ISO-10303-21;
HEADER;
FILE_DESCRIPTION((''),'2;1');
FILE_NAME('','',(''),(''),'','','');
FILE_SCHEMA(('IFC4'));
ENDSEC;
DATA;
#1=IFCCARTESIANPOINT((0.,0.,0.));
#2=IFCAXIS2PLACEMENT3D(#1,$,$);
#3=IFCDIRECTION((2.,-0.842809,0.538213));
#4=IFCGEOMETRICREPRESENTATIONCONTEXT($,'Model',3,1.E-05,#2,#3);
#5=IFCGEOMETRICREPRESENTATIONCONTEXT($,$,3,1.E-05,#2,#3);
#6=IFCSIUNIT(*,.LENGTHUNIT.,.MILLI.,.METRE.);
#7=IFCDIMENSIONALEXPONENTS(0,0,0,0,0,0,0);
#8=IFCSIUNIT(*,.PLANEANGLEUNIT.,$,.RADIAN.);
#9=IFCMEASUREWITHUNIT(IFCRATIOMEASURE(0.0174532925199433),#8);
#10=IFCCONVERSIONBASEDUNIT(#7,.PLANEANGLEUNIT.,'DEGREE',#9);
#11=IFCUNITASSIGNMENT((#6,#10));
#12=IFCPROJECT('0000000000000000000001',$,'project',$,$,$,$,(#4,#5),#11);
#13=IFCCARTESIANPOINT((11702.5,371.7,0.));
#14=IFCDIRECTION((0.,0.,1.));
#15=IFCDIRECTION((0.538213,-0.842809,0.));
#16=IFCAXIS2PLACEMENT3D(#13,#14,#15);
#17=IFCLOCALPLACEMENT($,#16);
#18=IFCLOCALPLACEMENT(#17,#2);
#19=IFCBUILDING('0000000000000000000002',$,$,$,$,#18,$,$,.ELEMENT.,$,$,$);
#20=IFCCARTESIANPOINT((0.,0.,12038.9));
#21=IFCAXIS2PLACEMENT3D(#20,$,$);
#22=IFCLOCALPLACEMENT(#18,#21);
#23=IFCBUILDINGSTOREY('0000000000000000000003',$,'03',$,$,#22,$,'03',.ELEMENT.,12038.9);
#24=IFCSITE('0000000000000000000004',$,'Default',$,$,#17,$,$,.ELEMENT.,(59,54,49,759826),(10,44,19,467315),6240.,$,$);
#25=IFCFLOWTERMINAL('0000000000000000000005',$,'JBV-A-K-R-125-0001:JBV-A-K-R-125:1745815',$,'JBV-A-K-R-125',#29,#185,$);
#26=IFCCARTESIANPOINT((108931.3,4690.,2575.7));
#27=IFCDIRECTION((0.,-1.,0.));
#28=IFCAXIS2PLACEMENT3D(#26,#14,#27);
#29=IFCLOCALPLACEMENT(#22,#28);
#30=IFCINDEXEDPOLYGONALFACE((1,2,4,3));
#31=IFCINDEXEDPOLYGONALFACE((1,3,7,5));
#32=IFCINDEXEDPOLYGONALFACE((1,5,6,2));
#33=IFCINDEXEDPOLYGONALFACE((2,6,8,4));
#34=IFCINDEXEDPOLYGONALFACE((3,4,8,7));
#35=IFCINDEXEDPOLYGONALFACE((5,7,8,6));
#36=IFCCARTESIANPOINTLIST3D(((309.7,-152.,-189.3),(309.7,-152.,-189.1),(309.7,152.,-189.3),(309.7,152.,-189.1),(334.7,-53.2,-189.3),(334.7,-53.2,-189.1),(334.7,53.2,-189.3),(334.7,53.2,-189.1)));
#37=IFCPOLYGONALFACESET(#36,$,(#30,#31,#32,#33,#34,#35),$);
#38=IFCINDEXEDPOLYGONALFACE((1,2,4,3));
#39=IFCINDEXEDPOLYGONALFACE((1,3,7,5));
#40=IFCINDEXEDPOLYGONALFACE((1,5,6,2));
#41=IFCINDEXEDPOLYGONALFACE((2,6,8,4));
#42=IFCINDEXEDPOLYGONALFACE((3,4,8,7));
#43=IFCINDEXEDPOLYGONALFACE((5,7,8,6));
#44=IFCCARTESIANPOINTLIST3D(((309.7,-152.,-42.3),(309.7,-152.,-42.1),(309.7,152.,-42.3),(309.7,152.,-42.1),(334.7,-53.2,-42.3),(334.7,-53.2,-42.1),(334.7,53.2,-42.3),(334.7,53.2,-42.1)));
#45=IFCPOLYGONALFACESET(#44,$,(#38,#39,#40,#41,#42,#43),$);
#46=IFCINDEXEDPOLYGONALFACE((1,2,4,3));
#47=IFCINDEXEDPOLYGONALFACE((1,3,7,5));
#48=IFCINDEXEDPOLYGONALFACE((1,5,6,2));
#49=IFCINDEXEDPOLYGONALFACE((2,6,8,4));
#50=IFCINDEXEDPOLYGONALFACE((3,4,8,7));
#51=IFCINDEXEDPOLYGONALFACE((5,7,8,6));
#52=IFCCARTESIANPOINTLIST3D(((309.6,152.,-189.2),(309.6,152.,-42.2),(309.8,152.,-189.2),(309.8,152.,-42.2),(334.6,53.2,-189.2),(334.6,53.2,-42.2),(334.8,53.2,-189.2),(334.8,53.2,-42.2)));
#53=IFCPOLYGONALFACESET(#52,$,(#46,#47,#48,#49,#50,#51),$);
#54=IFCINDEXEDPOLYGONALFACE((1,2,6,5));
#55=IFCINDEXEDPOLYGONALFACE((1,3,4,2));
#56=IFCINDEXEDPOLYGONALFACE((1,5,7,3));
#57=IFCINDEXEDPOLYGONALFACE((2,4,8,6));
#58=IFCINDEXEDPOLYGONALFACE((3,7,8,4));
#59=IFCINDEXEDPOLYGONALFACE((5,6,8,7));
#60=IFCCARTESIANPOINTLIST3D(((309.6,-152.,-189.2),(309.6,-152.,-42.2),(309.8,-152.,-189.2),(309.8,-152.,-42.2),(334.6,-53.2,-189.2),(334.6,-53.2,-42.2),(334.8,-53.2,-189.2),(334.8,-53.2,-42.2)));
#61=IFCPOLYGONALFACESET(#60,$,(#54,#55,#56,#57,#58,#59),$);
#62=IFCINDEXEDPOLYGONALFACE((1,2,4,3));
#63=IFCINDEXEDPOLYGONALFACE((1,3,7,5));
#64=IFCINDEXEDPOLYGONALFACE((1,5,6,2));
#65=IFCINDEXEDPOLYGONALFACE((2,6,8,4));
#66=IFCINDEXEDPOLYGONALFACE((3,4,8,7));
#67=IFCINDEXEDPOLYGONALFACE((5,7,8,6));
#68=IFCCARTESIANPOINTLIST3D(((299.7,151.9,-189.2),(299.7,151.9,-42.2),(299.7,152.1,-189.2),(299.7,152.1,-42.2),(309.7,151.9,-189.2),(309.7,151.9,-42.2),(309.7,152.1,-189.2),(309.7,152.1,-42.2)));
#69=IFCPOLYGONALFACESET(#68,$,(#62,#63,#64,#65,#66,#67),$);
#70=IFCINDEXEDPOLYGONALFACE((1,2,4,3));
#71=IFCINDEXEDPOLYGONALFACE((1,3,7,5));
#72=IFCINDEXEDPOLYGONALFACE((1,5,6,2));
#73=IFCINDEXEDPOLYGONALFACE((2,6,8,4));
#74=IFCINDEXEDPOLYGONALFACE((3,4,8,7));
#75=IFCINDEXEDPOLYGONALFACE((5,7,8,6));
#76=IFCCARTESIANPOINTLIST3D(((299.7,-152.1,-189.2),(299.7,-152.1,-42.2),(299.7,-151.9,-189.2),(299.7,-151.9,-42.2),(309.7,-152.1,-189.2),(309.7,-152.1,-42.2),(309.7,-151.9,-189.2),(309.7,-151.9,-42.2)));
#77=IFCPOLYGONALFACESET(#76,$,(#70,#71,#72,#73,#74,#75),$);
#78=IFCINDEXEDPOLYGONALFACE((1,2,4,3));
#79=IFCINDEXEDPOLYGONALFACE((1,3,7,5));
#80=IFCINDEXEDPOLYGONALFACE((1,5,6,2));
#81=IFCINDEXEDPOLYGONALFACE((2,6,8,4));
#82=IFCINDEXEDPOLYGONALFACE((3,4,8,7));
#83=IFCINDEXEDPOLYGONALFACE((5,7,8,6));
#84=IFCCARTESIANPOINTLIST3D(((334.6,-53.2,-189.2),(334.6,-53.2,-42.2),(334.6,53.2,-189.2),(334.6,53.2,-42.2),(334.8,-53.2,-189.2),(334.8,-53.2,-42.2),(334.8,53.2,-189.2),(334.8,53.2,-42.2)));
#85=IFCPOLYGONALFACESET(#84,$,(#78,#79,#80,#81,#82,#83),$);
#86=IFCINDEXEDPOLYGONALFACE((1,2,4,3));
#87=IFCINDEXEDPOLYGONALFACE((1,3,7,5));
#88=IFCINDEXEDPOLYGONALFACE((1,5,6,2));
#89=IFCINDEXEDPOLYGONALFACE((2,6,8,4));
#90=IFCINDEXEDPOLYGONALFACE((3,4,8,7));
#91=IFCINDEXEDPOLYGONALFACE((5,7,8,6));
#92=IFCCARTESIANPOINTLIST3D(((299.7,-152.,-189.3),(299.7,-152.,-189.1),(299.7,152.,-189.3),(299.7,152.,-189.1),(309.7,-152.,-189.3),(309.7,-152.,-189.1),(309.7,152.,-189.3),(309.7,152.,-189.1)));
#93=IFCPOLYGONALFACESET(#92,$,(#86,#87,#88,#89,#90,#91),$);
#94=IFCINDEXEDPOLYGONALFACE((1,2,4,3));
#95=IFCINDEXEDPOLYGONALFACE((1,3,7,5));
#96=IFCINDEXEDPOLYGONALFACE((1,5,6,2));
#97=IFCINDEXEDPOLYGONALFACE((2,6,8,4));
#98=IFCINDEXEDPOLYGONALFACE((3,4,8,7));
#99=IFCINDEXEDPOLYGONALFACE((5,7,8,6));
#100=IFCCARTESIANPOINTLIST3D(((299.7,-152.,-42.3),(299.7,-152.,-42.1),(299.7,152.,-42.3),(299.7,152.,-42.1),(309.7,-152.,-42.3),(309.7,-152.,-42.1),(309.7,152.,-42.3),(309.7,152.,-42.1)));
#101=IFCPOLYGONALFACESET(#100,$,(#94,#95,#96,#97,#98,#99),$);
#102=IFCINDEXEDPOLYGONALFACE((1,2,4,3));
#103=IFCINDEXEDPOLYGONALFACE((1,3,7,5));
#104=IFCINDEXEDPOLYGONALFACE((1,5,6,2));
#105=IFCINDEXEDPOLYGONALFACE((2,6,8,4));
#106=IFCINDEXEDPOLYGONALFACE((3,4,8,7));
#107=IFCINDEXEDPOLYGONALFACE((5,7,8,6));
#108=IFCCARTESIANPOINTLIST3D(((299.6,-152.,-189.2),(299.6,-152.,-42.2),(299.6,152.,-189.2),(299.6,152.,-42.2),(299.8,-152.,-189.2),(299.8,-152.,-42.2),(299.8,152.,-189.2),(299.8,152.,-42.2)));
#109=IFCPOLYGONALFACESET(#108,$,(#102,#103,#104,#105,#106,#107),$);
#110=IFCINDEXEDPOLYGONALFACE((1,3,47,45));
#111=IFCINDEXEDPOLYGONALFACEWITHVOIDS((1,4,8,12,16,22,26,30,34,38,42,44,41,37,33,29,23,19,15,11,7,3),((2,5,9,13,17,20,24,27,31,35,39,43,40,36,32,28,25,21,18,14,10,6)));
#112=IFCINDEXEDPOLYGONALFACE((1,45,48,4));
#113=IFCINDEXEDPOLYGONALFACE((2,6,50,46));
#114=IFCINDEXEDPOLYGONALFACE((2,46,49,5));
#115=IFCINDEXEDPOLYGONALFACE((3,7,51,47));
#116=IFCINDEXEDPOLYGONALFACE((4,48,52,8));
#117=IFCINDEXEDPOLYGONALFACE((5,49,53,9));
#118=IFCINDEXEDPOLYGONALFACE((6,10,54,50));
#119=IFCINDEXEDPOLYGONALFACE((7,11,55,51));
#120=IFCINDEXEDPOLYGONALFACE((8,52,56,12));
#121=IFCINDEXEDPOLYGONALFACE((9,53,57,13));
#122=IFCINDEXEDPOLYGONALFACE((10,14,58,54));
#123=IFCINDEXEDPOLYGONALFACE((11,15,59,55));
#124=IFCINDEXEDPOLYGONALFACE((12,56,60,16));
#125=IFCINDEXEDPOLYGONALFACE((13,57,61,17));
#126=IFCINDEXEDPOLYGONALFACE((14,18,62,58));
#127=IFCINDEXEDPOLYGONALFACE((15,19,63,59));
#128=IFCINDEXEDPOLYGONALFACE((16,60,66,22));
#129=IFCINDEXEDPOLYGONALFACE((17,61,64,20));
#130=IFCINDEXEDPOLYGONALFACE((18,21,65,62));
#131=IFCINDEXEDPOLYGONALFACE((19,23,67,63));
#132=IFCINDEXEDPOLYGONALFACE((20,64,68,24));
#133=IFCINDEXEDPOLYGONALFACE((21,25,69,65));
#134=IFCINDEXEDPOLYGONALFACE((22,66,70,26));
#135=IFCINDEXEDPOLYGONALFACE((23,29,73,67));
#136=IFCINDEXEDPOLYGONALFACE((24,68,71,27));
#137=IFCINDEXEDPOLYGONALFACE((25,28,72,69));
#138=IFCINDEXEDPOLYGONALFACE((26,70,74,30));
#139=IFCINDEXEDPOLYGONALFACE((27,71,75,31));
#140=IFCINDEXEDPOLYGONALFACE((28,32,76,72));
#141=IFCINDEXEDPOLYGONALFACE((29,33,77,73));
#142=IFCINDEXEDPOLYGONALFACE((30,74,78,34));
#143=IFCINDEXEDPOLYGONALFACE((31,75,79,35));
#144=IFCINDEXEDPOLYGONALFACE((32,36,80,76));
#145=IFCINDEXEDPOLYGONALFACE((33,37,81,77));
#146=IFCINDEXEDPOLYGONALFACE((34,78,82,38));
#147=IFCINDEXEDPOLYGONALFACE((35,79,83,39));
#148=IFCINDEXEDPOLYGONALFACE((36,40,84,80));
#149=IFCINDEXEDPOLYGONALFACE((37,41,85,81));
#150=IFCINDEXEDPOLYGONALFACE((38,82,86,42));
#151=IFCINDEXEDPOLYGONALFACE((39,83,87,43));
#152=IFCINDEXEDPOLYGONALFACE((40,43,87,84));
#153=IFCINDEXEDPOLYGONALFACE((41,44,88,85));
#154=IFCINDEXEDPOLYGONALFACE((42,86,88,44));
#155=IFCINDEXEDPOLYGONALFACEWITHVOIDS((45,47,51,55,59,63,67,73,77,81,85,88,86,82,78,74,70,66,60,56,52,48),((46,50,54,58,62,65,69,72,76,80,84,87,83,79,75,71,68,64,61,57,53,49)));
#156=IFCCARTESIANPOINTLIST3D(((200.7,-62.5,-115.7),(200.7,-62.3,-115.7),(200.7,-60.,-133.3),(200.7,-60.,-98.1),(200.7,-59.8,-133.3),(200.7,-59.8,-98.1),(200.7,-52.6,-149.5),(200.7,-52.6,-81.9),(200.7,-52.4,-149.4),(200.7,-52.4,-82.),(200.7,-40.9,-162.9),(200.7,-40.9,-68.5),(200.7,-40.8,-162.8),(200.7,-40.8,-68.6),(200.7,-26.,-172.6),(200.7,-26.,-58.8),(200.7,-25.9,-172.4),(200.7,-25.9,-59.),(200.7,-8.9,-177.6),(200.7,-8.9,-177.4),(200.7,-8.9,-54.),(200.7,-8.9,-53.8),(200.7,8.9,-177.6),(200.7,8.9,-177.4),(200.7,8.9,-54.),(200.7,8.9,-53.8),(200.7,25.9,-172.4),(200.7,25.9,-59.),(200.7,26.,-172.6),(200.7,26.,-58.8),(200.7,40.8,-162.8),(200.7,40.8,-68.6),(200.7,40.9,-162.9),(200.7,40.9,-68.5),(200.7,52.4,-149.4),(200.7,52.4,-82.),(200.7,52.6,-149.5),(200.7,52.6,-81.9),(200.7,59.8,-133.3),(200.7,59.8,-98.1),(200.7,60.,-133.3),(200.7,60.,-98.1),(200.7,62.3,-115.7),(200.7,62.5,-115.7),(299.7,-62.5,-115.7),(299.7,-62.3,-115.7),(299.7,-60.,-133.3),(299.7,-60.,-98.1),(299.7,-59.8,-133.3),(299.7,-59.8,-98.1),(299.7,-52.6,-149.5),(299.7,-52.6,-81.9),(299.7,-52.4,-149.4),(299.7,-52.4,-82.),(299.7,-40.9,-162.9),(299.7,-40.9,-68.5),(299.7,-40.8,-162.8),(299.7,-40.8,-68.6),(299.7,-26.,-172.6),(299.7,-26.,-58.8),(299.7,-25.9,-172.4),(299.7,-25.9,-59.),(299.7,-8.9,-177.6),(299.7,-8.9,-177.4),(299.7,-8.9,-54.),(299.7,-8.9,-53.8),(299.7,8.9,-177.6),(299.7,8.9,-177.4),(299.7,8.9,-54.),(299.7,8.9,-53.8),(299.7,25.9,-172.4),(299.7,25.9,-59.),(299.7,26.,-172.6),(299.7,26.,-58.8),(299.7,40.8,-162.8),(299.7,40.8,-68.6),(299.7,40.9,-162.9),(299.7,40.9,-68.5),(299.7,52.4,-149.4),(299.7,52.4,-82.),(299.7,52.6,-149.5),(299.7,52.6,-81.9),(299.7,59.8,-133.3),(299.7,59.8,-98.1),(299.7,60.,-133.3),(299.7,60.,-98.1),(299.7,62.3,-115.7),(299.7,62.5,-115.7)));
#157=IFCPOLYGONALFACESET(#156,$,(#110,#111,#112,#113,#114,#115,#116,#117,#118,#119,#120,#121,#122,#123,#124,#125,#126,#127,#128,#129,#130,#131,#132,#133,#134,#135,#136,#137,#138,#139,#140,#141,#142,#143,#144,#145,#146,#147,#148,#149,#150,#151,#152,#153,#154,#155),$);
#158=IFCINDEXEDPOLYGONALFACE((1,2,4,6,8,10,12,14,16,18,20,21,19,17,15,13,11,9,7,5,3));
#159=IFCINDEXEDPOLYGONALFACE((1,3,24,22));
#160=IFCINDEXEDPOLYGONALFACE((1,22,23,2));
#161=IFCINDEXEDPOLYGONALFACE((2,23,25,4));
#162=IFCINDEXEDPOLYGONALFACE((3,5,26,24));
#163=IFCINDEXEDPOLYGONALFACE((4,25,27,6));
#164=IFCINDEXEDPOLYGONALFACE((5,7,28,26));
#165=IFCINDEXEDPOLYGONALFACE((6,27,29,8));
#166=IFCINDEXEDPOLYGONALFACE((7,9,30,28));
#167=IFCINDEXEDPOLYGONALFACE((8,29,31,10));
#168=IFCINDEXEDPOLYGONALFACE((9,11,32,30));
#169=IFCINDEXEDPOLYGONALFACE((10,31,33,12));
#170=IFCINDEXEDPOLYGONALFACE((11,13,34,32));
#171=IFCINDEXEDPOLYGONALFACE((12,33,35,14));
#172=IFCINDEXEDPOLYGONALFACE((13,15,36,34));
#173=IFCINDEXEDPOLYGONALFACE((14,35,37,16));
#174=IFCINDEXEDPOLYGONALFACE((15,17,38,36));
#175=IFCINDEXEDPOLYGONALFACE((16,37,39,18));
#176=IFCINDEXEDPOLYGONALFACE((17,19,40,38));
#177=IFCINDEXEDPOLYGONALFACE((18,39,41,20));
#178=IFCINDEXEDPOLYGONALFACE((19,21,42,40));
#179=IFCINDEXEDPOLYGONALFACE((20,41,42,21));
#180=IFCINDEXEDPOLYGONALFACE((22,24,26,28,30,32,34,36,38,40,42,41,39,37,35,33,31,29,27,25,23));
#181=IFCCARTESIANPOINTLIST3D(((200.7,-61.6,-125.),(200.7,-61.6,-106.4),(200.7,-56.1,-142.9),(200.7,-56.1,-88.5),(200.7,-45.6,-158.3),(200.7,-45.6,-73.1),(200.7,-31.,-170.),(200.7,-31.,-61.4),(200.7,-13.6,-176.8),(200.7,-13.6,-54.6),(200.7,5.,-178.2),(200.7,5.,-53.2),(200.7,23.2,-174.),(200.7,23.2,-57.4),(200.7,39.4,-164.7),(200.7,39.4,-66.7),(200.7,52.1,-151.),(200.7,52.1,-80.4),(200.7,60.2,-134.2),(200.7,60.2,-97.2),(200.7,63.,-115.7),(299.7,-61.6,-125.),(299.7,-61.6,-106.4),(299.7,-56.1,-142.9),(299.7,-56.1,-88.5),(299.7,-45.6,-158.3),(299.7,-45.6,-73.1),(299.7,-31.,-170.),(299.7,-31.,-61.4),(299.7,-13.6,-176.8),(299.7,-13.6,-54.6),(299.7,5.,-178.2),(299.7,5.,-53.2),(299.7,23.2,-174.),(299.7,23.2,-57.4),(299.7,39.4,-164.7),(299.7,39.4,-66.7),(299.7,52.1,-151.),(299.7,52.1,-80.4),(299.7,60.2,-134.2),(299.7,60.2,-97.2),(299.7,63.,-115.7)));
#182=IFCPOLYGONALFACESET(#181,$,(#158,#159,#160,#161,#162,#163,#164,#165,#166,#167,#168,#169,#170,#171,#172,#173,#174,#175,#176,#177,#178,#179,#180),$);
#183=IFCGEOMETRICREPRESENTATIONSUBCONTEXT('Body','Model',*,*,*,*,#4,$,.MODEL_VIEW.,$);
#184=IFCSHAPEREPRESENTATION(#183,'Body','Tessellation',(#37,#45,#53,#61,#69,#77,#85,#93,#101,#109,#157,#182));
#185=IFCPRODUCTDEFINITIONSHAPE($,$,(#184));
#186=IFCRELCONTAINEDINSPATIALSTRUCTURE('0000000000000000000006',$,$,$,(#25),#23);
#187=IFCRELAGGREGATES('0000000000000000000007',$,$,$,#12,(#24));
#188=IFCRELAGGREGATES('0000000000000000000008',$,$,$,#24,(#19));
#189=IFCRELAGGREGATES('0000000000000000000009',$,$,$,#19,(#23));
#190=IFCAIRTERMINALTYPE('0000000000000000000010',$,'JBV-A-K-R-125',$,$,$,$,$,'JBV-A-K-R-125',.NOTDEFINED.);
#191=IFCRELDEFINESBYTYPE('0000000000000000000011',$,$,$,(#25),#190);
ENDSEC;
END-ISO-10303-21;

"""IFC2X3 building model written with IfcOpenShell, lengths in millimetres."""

from ifc_helpers import new_model, entity, si_unit, converted_unit, direction, frame, frame_2d, origin, origin_2d_with_axis, place, context, subcontext, project, spatial, polyline, circle_curve, parameter, trimmed, segment, composite_curve, rectangle, circle, outline, extrude, source, transform, mapped, type_object, type_shapes, element, save


model = new_model("IFC2X3")

# Units and contexts
model_context = context("Model", 3, precision=1e-05, world=origin(), true_north=direction((2.0, -0.842809, 0.538213)))
context_of_model = context(None, 3, precision=1e-05, world=origin(), true_north=direction((2.0, -0.842809, 0.538213)))
body_context = subcontext(model_context, "Body", "Model", "MODEL_VIEW")
ifc_project = project(units=[si_unit("LENGTHUNIT", "METRE", prefix="MILLI"), converted_unit("PLANEANGLEUNIT", "DEGREE", entity("IfcRatioMeasure", 0.0174532925199433), si_unit("PLANEANGLEUNIT", "RADIAN"), dimensions=[0, 0, 0, 0, 0, 0, 0])], contexts=[model_context, context_of_model])

# Site, building, storey
site_placement = place(None, frame((11702.5, 371.7, 0.0), z_axis=(0.0, 0.0, 1.0), x_axis=(0.538213, -0.842809, 0.0)))
site = spatial("IfcSite", under=ifc_project, at=site_placement, Name="Default", CompositionType="ELEMENT", RefLatitude=(59, 54, 49, 759826), RefLongitude=(10, 44, 19, 467315), RefElevation=6240.0)
building_placement = place(site_placement, origin())
building = spatial("IfcBuilding", under=site, at=building_placement, CompositionType="ELEMENT")
storey_placement = place(building_placement, frame((0.0, 0.0, 12038.9)))
storey = spatial("IfcBuildingStorey", under=building, at=storey_placement, Name="03", LongName="03", CompositionType="ELEMENT", Elevation=12038.9)

# Flow terminal
air_terminal_type_1 = type_object("IfcAirTerminalType", Name="JBV-A-K-R-125", ElementType="JBV-A-K-R-125", PredefinedType="NOTDEFINED")
shared_shape_1 = source(origin(), body_context, "Body", "SweptSolid", [
    extrude(outline(polyline([(-152.0, -12.5), (152.0, -12.5), (53.2, 12.5), (-53.2, 12.5), (-152.0, -12.5)])), frame((322.2, 0.0, -189.3), z_axis=(0.0, 0.0, 1.0), x_axis=(0.0, -1.0, 0.0)), (0.0, 0.0, 1.0), 0.2),
    extrude(outline(polyline([(-152.0, -12.5), (152.0, -12.5), (53.2, 12.5), (-53.2, 12.5), (-152.0, -12.5)])), frame((322.2, 0.0, -42.3), z_axis=(0.0, 0.0, 1.0), x_axis=(0.0, -1.0, 0.0)), (0.0, 0.0, 1.0), 0.2),
    extrude(rectangle(XDim=0.2, YDim=101.9, at=frame_2d((0.0, 0.0), x_axis=(1.0, 0.0))), frame((322.2, 102.6, -189.2), z_axis=(0.0, 0.0, 1.0), x_axis=(0.969446, 0.245305, 0.0)), (0.0, 0.0, 1.0), 147.0),
    extrude(rectangle(XDim=0.2, YDim=101.9, at=frame_2d((0.0, 0.0), x_axis=(1.0, 0.0))), frame((322.2, -102.6, -189.2), z_axis=(0.0, 0.0, 1.0), x_axis=(-0.969446, 0.245305, 0.0)), (0.0, 0.0, 1.0), 147.0),
    extrude(rectangle(XDim=0.2, YDim=10.0, at=frame_2d((0.0, 0.0), x_axis=(1.0, 0.0))), frame((304.7, 152.0, -189.2), z_axis=(0.0, 0.0, 1.0), x_axis=(0.0, 1.0, 0.0)), (0.0, 0.0, 1.0), 147.0),
    extrude(rectangle(XDim=0.2, YDim=10.0, at=frame_2d((0.0, 0.0), x_axis=(1.0, 0.0))), frame((304.7, -152.0, -189.2), z_axis=(0.0, 0.0, 1.0), x_axis=(0.0, 1.0, 0.0)), (0.0, 0.0, 1.0), 147.0),
    extrude(rectangle(XDim=0.2, YDim=106.4, at=frame_2d((0.0, 0.0), x_axis=(1.0, 0.0))), frame((334.7, 0.0, -189.2)), (0.0, 0.0, 1.0), 147.0),
    extrude(rectangle(XDim=304.0, YDim=10.0, at=frame_2d((0.0, 0.0), x_axis=(1.0, 0.0))), frame((304.7, 0.0, -189.3), z_axis=(0.0, 0.0, 1.0), x_axis=(0.0, -1.0, 0.0)), (0.0, 0.0, 1.0), 0.2),
    extrude(rectangle(XDim=304.0, YDim=10.0, at=frame_2d((0.0, 0.0), x_axis=(1.0, 0.0))), frame((304.7, 0.0, -42.3), z_axis=(0.0, 0.0, 1.0), x_axis=(0.0, -1.0, 0.0)), (0.0, 0.0, 1.0), 0.2),
    extrude(rectangle(XDim=0.2, YDim=304.0, at=frame_2d((0.0, 0.0), x_axis=(1.0, 0.0))), frame((299.7, 0.0, -189.2)), (0.0, 0.0, 1.0), 147.0),
    extrude(outline(composite_curve([segment(trimmed(circle_curve(origin_2d_with_axis(), 62.5), [parameter(0.0)], [parameter(180.0)], True, "PARAMETER"), True, "CONTINUOUS"), segment(trimmed(circle_curve(origin_2d_with_axis(), 62.5), [parameter(180.0)], [parameter(360.0)], True, "PARAMETER"), True, "CONTINUOUS")], self_intersect=False), holes=[composite_curve([segment(trimmed(circle_curve(origin_2d_with_axis(), 62.3), [parameter(180.0)], [parameter(360.0)], True, "PARAMETER"), False, "CONTINUOUS"), segment(trimmed(circle_curve(origin_2d_with_axis(), 62.3), [parameter(0.0)], [parameter(180.0)], True, "PARAMETER"), False, "CONTINUOUS")], self_intersect=False)]), frame((200.7, 0.0, -115.7), z_axis=(1.0, 0.0, 0.0), x_axis=(0.0, 1.0, 0.0)), (0.0, 0.0, 1.0), 99.0),
    extrude(circle(Radius=62.6, at=frame_2d((0.0, 0.0), x_axis=(1.0, 0.0))), frame((200.7, 0.3, -115.7), z_axis=(1.0, 0.0, 0.0), x_axis=(0.0, 1.0, 0.0)), (0.0, 0.0, 1.0), 99.0),
])
type_shapes(air_terminal_type_1, [shared_shape_1])
for number, where, z_axis, x_axis, name in (
    (1, (108931.3, 4690.0, 2575.7), (0.0, 0.0, 1.0), (0.0, -1.0, 0.0), "JBV-A-K-R-125-0001:JBV-A-K-R-125:1745815"),
):
    element("IfcFlowTerminal", number, at=place(storey_placement, frame(where, z_axis=z_axis, x_axis=x_axis)), inside=storey, type_object=air_terminal_type_1, Name=name, ObjectType="JBV-A-K-R-125", context=body_context, shape_type="MappedRepresentation", body=[
        mapped(shared_shape_1, transform((0.0, 0.0, 0.0), scale=1.0)),
    ])

save(model, "model.ifc")
